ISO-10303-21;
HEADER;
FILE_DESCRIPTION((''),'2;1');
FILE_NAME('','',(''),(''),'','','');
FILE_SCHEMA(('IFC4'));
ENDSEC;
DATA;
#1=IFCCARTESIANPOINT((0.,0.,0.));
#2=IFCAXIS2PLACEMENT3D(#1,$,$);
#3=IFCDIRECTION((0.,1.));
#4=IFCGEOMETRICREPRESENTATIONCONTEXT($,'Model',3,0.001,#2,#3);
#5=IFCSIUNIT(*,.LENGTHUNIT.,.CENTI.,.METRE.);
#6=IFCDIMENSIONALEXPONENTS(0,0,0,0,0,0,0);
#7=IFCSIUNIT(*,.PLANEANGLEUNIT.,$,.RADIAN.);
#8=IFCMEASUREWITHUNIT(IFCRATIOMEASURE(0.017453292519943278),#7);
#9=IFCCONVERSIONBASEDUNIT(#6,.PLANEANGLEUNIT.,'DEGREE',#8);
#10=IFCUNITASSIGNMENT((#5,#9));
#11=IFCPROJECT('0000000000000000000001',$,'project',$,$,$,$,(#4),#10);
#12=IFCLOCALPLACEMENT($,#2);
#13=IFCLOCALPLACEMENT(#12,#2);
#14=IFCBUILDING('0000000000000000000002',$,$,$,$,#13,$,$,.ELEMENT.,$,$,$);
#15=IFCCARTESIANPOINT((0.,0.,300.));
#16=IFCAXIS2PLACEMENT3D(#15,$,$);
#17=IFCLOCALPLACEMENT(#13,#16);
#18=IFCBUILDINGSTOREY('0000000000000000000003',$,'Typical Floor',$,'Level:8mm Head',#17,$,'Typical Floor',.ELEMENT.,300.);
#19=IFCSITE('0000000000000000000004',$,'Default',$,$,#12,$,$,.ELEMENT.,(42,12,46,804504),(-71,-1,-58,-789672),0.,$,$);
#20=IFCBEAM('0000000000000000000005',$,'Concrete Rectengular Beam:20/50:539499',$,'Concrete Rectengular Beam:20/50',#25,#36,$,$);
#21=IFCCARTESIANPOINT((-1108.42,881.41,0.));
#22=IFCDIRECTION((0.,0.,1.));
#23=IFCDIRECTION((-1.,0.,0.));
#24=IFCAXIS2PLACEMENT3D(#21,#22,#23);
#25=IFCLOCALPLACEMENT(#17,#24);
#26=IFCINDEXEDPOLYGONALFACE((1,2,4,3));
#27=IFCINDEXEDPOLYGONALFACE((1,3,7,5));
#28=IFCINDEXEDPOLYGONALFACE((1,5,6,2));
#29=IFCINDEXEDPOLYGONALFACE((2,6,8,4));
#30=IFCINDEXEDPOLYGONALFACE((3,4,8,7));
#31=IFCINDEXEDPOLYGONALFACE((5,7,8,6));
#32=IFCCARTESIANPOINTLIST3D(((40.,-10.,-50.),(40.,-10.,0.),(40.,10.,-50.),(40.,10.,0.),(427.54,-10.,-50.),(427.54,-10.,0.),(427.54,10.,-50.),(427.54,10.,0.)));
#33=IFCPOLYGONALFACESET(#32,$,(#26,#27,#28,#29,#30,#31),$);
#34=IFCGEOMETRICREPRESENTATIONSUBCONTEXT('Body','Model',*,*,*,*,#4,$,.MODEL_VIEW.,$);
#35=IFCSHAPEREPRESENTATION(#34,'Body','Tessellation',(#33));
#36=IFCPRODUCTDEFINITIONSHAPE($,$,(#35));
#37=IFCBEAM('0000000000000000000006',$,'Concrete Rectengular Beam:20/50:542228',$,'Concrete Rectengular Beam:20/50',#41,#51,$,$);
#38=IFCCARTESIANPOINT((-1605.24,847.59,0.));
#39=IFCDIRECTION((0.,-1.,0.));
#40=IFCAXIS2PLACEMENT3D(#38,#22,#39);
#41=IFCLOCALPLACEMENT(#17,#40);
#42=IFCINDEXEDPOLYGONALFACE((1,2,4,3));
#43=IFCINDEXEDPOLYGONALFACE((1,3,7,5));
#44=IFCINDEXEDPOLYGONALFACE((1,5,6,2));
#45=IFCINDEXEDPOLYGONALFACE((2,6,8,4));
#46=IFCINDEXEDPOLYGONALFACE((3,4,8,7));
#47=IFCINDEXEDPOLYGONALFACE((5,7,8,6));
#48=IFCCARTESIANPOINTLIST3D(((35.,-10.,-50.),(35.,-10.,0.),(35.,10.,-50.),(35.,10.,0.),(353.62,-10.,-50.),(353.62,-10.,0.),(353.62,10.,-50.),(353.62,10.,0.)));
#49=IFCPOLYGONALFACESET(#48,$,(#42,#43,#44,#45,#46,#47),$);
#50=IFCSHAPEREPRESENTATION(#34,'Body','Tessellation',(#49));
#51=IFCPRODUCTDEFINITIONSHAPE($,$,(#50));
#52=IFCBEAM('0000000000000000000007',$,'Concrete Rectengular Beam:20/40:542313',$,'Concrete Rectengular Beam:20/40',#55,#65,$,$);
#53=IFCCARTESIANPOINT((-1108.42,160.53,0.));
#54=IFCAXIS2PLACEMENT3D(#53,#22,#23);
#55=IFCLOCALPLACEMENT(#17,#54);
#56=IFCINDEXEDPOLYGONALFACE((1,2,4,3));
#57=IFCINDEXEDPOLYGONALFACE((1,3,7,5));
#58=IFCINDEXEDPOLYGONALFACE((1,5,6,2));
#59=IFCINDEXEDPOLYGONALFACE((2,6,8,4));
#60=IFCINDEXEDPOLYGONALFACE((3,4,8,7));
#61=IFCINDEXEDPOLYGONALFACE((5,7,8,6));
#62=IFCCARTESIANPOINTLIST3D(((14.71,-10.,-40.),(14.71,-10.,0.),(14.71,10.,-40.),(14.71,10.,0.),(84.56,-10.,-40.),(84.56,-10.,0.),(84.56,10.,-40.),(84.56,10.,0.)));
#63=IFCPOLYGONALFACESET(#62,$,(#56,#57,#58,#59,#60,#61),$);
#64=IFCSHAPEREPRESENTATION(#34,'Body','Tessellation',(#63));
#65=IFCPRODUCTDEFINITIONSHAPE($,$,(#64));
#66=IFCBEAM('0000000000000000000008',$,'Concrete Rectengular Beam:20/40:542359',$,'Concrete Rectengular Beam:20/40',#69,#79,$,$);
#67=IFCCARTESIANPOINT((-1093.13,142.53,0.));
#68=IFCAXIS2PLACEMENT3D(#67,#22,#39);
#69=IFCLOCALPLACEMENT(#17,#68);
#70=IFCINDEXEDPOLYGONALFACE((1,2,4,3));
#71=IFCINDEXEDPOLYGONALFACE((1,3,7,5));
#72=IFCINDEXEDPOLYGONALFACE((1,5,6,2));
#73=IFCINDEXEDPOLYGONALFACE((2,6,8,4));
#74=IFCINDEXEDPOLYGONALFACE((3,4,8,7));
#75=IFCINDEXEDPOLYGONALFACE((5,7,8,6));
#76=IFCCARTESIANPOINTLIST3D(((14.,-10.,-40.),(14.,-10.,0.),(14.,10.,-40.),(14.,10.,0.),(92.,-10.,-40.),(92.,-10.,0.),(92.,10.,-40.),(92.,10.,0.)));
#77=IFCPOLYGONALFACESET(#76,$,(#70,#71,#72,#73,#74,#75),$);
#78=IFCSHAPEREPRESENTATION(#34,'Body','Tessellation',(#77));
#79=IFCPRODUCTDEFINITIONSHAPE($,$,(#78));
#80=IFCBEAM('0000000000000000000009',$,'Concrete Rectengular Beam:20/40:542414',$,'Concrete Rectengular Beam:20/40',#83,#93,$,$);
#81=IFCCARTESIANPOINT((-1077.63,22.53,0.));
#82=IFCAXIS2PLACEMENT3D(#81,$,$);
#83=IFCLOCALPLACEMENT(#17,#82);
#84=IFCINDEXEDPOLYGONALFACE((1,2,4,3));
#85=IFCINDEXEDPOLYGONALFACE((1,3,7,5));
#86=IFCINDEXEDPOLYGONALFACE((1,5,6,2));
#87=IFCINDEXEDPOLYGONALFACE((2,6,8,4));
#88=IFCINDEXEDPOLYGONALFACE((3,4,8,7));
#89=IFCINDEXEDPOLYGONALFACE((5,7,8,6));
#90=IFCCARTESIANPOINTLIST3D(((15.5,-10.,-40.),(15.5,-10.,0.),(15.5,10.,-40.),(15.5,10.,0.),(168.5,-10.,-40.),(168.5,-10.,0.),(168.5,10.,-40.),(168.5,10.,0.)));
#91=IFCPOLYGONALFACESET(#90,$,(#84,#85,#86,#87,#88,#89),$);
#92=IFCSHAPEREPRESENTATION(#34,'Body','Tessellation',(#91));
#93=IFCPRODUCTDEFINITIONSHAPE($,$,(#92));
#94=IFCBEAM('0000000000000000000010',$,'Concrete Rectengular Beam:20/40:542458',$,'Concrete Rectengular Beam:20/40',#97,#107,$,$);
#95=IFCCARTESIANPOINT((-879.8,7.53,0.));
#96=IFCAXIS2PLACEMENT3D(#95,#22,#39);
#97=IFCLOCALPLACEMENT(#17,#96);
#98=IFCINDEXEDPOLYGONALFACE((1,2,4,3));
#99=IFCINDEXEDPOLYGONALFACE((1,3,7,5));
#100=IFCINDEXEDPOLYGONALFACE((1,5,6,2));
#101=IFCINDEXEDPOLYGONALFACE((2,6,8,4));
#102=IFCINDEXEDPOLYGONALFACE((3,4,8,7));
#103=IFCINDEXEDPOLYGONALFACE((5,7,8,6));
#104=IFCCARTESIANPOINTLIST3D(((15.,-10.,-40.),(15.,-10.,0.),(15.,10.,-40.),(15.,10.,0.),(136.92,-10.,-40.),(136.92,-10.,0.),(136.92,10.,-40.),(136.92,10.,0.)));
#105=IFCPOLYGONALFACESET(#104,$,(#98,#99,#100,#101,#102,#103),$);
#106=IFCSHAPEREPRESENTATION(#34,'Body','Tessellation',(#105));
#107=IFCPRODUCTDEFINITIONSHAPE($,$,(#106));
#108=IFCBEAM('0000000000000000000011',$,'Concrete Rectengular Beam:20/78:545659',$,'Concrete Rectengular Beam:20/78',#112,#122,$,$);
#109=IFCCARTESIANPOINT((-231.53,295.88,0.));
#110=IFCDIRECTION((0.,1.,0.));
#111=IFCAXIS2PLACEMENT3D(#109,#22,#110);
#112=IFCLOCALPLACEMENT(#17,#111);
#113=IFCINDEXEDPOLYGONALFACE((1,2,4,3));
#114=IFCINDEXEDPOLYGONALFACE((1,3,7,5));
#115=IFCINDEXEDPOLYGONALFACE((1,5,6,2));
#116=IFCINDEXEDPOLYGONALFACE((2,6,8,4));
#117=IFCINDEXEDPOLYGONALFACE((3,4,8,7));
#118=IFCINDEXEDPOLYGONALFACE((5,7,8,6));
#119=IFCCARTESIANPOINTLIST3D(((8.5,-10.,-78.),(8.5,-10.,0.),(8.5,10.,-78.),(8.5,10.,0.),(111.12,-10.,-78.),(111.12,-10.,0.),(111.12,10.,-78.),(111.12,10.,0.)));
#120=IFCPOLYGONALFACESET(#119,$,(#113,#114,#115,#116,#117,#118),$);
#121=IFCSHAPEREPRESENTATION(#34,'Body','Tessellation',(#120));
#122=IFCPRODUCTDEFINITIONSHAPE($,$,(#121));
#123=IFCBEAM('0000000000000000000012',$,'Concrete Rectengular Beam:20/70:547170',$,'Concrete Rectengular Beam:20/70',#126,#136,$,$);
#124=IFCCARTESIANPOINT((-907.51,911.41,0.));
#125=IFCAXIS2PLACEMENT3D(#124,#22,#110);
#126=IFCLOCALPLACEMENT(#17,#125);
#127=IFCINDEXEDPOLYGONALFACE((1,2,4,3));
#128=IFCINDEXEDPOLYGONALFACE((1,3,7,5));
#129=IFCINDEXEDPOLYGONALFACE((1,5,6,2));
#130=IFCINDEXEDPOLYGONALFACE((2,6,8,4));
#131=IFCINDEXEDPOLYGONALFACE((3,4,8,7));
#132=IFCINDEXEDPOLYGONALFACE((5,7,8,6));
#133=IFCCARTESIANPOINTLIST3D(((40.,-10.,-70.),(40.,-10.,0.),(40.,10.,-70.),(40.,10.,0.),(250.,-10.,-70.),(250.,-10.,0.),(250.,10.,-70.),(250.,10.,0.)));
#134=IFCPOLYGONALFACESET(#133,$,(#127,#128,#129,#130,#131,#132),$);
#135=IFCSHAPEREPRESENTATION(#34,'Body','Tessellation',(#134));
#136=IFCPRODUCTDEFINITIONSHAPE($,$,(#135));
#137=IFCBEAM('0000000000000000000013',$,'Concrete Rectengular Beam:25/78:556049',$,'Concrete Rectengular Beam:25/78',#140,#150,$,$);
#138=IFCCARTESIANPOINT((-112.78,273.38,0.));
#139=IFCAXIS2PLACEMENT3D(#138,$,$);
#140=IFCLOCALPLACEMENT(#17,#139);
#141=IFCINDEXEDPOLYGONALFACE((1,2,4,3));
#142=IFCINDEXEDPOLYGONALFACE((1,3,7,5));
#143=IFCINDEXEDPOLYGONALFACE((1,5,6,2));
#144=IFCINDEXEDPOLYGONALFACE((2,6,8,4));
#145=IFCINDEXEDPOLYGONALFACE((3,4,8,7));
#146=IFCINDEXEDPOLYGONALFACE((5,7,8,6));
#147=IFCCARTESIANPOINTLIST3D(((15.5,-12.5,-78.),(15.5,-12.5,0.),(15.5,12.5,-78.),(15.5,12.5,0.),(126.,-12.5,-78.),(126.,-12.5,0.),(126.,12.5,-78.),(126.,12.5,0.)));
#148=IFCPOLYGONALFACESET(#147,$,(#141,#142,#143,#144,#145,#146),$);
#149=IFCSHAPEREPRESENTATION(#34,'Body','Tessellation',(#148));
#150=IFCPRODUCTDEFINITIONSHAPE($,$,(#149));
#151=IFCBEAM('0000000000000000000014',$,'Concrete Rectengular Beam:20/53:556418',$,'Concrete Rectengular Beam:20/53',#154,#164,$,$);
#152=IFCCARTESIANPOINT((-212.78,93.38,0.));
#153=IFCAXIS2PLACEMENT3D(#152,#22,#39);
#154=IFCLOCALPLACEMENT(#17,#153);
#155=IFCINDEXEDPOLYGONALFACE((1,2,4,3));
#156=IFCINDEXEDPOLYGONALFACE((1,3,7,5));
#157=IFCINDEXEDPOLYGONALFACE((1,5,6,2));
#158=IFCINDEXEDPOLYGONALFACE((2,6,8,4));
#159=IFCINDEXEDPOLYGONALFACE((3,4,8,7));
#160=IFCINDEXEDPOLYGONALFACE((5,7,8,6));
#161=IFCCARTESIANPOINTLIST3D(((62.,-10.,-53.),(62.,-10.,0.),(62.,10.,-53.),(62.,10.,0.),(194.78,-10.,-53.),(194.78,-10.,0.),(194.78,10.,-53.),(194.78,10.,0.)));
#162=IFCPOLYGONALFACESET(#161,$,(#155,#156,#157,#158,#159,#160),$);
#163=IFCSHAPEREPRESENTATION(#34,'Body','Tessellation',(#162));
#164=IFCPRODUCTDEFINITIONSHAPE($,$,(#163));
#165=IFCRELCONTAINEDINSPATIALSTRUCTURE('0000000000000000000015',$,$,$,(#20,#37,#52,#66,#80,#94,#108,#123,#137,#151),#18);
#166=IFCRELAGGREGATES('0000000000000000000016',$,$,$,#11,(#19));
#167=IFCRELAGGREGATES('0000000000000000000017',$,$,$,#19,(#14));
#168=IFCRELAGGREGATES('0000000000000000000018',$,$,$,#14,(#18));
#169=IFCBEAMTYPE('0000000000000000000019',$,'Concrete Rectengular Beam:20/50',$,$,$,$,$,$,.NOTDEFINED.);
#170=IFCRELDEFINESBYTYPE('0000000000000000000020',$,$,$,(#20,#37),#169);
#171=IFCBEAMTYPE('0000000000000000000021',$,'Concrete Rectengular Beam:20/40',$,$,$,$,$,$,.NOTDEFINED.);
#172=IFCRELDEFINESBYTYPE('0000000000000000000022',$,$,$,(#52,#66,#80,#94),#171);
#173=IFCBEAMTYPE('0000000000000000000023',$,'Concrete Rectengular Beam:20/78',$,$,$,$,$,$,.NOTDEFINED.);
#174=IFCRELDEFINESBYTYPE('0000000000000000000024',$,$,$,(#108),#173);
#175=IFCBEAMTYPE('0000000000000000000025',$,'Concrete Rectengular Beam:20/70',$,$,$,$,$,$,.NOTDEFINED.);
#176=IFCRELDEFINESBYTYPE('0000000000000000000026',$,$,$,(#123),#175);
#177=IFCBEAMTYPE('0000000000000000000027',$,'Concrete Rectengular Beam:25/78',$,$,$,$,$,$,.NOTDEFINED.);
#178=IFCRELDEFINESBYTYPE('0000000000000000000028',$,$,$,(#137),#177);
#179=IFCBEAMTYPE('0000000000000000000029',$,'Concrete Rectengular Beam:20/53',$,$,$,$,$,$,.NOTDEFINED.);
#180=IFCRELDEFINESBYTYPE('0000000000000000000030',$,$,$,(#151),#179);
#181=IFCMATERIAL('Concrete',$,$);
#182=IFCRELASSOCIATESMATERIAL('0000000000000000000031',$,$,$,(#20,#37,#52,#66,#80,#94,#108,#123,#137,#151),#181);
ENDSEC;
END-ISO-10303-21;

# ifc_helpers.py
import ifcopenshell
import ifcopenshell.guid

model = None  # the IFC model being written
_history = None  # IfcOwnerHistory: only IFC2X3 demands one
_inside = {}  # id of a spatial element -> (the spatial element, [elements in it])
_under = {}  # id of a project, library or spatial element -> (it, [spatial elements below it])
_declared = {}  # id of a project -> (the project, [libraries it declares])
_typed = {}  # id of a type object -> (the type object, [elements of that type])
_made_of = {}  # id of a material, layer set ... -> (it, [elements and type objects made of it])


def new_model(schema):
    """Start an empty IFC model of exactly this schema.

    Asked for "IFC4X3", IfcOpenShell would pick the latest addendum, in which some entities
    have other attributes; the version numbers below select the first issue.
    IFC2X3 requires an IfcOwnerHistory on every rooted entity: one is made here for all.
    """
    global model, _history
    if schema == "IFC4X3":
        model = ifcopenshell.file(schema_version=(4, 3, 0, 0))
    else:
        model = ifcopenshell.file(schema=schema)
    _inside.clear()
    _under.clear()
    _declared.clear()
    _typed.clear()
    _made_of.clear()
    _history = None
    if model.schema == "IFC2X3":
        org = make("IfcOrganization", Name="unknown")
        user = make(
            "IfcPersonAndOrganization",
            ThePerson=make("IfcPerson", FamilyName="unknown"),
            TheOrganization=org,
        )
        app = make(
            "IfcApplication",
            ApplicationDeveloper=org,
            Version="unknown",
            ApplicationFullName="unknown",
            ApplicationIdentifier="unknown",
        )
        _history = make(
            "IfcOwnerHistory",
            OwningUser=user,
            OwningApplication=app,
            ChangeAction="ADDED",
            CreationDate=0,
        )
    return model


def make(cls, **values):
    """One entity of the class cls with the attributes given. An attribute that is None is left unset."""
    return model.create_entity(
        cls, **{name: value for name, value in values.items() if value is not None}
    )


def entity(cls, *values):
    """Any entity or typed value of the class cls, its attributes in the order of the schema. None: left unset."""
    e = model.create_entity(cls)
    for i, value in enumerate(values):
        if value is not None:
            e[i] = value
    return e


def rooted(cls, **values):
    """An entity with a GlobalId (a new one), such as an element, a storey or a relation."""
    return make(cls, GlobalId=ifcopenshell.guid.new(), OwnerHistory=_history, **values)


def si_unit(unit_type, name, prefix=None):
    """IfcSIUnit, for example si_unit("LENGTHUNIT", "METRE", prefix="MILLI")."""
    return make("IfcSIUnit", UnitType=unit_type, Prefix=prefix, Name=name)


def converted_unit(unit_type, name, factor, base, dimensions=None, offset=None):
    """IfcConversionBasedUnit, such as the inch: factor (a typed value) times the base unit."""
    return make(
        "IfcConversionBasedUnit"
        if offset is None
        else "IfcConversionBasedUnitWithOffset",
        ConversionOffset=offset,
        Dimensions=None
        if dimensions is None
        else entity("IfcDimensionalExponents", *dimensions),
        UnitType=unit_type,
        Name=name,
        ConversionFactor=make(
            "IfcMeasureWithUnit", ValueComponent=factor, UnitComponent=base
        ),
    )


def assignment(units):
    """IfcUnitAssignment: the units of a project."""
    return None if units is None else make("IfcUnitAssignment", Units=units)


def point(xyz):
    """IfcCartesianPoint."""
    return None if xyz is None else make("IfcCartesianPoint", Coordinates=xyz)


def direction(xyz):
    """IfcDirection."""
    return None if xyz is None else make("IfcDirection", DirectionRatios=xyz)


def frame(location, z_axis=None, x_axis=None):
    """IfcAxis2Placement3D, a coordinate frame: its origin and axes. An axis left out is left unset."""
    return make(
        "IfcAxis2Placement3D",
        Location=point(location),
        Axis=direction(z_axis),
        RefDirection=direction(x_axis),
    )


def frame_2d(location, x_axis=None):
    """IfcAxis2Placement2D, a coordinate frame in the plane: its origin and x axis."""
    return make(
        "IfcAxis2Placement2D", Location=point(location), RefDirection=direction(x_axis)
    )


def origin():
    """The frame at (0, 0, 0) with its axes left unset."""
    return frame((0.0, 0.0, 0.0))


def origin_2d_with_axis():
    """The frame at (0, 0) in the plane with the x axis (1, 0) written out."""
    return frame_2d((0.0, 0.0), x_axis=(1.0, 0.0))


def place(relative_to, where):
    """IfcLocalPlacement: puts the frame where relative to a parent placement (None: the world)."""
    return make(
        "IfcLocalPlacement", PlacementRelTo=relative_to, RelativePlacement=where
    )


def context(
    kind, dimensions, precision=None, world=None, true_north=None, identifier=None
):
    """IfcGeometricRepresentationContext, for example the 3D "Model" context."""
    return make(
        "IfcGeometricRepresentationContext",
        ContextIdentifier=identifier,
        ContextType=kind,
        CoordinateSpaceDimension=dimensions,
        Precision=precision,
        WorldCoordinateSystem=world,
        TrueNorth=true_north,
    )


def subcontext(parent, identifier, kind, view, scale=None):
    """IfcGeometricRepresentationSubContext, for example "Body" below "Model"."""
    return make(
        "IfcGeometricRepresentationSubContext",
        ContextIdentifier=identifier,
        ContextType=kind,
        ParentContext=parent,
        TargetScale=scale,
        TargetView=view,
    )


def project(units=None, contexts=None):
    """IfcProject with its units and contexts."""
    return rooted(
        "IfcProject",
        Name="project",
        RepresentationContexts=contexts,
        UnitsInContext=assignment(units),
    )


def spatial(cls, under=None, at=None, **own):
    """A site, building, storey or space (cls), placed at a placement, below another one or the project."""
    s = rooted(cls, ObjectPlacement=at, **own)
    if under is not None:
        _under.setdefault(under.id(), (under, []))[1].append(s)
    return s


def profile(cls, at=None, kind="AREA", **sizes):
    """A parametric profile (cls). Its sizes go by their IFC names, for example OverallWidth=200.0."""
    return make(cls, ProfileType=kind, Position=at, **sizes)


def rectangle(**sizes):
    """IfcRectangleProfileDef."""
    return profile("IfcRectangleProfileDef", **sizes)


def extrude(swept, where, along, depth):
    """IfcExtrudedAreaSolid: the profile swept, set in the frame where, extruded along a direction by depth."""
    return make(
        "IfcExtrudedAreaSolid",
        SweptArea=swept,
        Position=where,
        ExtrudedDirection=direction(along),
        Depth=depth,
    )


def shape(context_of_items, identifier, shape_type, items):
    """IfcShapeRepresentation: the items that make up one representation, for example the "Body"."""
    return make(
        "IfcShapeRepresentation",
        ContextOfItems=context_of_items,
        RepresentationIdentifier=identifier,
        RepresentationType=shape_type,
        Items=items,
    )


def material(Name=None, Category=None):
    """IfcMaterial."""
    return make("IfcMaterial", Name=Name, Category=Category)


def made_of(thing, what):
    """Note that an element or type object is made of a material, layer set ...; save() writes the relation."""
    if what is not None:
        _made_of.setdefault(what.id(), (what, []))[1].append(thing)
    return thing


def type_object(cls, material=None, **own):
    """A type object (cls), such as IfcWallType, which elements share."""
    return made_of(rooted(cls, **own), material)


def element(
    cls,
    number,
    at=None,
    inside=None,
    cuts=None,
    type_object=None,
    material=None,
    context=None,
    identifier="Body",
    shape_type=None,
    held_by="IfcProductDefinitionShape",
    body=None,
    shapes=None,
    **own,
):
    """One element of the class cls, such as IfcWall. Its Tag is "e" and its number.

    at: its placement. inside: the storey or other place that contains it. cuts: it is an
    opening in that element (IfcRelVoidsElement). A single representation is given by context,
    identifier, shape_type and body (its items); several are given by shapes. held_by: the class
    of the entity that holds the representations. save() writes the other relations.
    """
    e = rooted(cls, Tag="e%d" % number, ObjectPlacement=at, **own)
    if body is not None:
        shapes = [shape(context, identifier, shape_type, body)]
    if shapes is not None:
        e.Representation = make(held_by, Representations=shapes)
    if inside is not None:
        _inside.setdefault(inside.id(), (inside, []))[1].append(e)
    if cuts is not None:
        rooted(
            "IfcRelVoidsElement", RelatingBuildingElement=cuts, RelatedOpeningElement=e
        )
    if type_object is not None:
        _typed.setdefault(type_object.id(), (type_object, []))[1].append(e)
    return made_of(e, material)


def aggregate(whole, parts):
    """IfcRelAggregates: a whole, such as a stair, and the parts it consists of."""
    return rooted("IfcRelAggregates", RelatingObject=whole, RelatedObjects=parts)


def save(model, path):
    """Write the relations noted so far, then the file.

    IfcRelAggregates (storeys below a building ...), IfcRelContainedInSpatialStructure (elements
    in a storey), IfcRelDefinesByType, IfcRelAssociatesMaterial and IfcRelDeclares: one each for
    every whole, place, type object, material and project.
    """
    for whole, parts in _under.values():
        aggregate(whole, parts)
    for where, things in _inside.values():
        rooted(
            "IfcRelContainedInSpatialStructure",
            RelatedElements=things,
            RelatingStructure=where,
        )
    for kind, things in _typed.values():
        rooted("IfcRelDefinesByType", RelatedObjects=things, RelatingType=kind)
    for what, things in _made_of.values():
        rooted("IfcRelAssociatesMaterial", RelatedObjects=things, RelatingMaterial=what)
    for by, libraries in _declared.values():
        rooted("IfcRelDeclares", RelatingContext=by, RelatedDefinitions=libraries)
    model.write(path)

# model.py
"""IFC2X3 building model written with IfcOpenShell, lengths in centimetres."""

from ifc_helpers import new_model, entity, si_unit, converted_unit, direction, frame, frame_2d, origin, origin_2d_with_axis, place, context, subcontext, project, spatial, rectangle, extrude, material, type_object, element, save


model = new_model("IFC2X3")

# Units and contexts
model_context = context("Model", 3, precision=0.001, world=origin(), true_north=direction((0.0, 1.0)))
body_context = subcontext(model_context, "Body", "Model", "MODEL_VIEW")
ifc_project = project(units=[si_unit("LENGTHUNIT", "METRE", prefix="CENTI"), converted_unit("PLANEANGLEUNIT", "DEGREE", entity("IfcRatioMeasure", 0.017453292519943278), si_unit("PLANEANGLEUNIT", "RADIAN"), dimensions=[0, 0, 0, 0, 0, 0, 0])], contexts=[model_context])

# Site, building, storey
site_placement = place(None, origin())
site = spatial("IfcSite", under=ifc_project, at=site_placement, Name="Default", CompositionType="ELEMENT", RefLatitude=(42, 12, 46, 804504), RefLongitude=(-71, -1, -58, -789672), RefElevation=0.0)
building_placement = place(site_placement, origin())
building = spatial("IfcBuilding", under=site, at=building_placement, CompositionType="ELEMENT")
storey_placement = place(building_placement, frame((0.0, 0.0, 300.0)))
storey = spatial("IfcBuildingStorey", under=building, at=storey_placement, Name="Typical Floor", ObjectType="Level:8mm Head", LongName="Typical Floor", CompositionType="ELEMENT", Elevation=300.0)

# Beams
ifc_material = material(Name="Concrete")
beam_type_1 = type_object("IfcBeamType", Name="Concrete Rectengular Beam:20/50", PredefinedType="NOTDEFINED")
beam_1_placement = place(storey_placement, frame((-1108.42, 881.41, 0.0), z_axis=(0.0, 0.0, 1.0), x_axis=(-1.0, 0.0, 0.0)))
element("IfcBeam", 1, at=beam_1_placement, inside=storey, type_object=beam_type_1, material=ifc_material, Name="Concrete Rectengular Beam:20/50:539499", ObjectType="Concrete Rectengular Beam:20/50", context=body_context, shape_type="SweptSolid", body=[
    extrude(rectangle(XDim=50.0, YDim=20.0, at=frame_2d((0.0, 0.0), x_axis=(1.0, 0.0))), frame((40.0, 0.0, -25.0), z_axis=(1.0, 0.0, 0.0), x_axis=(0.0, 0.0, -1.0)), (0.0, 0.0, 1.0), 387.54),
])
beam_2_placement = place(storey_placement, frame((-1605.24, 847.59, 0.0), z_axis=(0.0, 0.0, 1.0), x_axis=(0.0, -1.0, 0.0)))
element("IfcBeam", 2, at=beam_2_placement, inside=storey, type_object=beam_type_1, material=ifc_material, Name="Concrete Rectengular Beam:20/50:542228", ObjectType="Concrete Rectengular Beam:20/50", context=body_context, shape_type="SweptSolid", body=[
    extrude(rectangle(XDim=50.0, YDim=20.0, at=frame_2d((0.0, 0.0), x_axis=(1.0, 0.0))), frame((35.0, 0.0, -25.0), z_axis=(1.0, 0.0, 0.0), x_axis=(0.0, 0.0, -1.0)), (0.0, 0.0, 1.0), 318.62),
])
beam_type_2 = type_object("IfcBeamType", Name="Concrete Rectengular Beam:20/40", PredefinedType="NOTDEFINED")
beam_3_placement = place(storey_placement, frame((-1108.42, 160.53, 0.0), z_axis=(0.0, 0.0, 1.0), x_axis=(-1.0, 0.0, 0.0)))
element("IfcBeam", 3, at=beam_3_placement, inside=storey, type_object=beam_type_2, material=ifc_material, Name="Concrete Rectengular Beam:20/40:542313", ObjectType="Concrete Rectengular Beam:20/40", context=body_context, shape_type="SweptSolid", body=[
    extrude(rectangle(XDim=40.0, YDim=20.0, at=frame_2d((0.0, 0.0), x_axis=(1.0, 0.0))), frame((14.71, 0.0, -20.0), z_axis=(1.0, 0.0, 0.0), x_axis=(0.0, 0.0, -1.0)), (0.0, 0.0, 1.0), 69.85),
])
beam_4_placement = place(storey_placement, frame((-1093.13, 142.53, 0.0), z_axis=(0.0, 0.0, 1.0), x_axis=(0.0, -1.0, 0.0)))
element("IfcBeam", 4, at=beam_4_placement, inside=storey, type_object=beam_type_2, material=ifc_material, Name="Concrete Rectengular Beam:20/40:542359", ObjectType="Concrete Rectengular Beam:20/40", context=body_context, shape_type="SweptSolid", body=[
    extrude(rectangle(XDim=40.0, YDim=20.0, at=origin_2d_with_axis()), frame((14.0, 0.0, -20.0), z_axis=(1.0, 0.0, 0.0), x_axis=(0.0, 0.0, -1.0)), (0.0, 0.0, 1.0), 78.0),
])
beam_5_placement = place(storey_placement, frame((-1077.63, 22.53, 0.0)))
element("IfcBeam", 5, at=beam_5_placement, inside=storey, type_object=beam_type_2, material=ifc_material, Name="Concrete Rectengular Beam:20/40:542414", ObjectType="Concrete Rectengular Beam:20/40", context=body_context, shape_type="SweptSolid", body=[
    extrude(rectangle(XDim=40.0, YDim=20.0, at=frame_2d((0.0, 0.0), x_axis=(1.0, 0.0))), frame((15.5, 0.0, -20.0), z_axis=(1.0, 0.0, 0.0), x_axis=(0.0, 0.0, -1.0)), (0.0, 0.0, 1.0), 153.0),
])
beam_6_placement = place(storey_placement, frame((-879.8, 7.53, 0.0), z_axis=(0.0, 0.0, 1.0), x_axis=(0.0, -1.0, 0.0)))
element("IfcBeam", 6, at=beam_6_placement, inside=storey, type_object=beam_type_2, material=ifc_material, Name="Concrete Rectengular Beam:20/40:542458", ObjectType="Concrete Rectengular Beam:20/40", context=body_context, shape_type="SweptSolid", body=[
    extrude(rectangle(XDim=40.0, YDim=20.0, at=frame_2d((0.0, 0.0), x_axis=(1.0, 0.0))), frame((15.0, 0.0, -20.0), z_axis=(1.0, 0.0, 0.0), x_axis=(0.0, 0.0, -1.0)), (0.0, 0.0, 1.0), 121.92),
])
beam_type_3 = type_object("IfcBeamType", Name="Concrete Rectengular Beam:20/78", PredefinedType="NOTDEFINED")
beam_7_placement = place(storey_placement, frame((-231.53, 295.88, 0.0), z_axis=(0.0, 0.0, 1.0), x_axis=(0.0, 1.0, 0.0)))
element("IfcBeam", 7, at=beam_7_placement, inside=storey, type_object=beam_type_3, material=ifc_material, Name="Concrete Rectengular Beam:20/78:545659", ObjectType="Concrete Rectengular Beam:20/78", context=body_context, shape_type="SweptSolid", body=[
    extrude(rectangle(XDim=78.0, YDim=20.0, at=frame_2d((0.0, 0.0), x_axis=(1.0, 0.0))), frame((8.5, 0.0, -39.0), z_axis=(1.0, 0.0, 0.0), x_axis=(0.0, 0.0, -1.0)), (0.0, 0.0, 1.0), 102.62),
])
beam_type_4 = type_object("IfcBeamType", Name="Concrete Rectengular Beam:20/70", PredefinedType="NOTDEFINED")
beam_8_placement = place(storey_placement, frame((-907.51, 911.41, 0.0), z_axis=(0.0, 0.0, 1.0), x_axis=(0.0, 1.0, 0.0)))
element("IfcBeam", 8, at=beam_8_placement, inside=storey, type_object=beam_type_4, material=ifc_material, Name="Concrete Rectengular Beam:20/70:547170", ObjectType="Concrete Rectengular Beam:20/70", context=body_context, shape_type="SweptSolid", body=[
    extrude(rectangle(XDim=70.0, YDim=20.0, at=frame_2d((0.0, 0.0), x_axis=(1.0, 0.0))), frame((40.0, 0.0, -35.0), z_axis=(1.0, 0.0, 0.0), x_axis=(0.0, 0.0, -1.0)), (0.0, 0.0, 1.0), 210.0),
])
beam_type_5 = type_object("IfcBeamType", Name="Concrete Rectengular Beam:25/78", PredefinedType="NOTDEFINED")
beam_9_placement = place(storey_placement, frame((-112.78, 273.38, 0.0)))
element("IfcBeam", 9, at=beam_9_placement, inside=storey, type_object=beam_type_5, material=ifc_material, Name="Concrete Rectengular Beam:25/78:556049", ObjectType="Concrete Rectengular Beam:25/78", context=body_context, shape_type="SweptSolid", body=[
    extrude(rectangle(XDim=78.0, YDim=25.0, at=frame_2d((0.0, 0.0), x_axis=(1.0, 0.0))), frame((15.5, 0.0, -39.0), z_axis=(1.0, 0.0, 0.0), x_axis=(0.0, 0.0, -1.0)), (0.0, 0.0, 1.0), 110.5),
])
beam_type_6 = type_object("IfcBeamType", Name="Concrete Rectengular Beam:20/53", PredefinedType="NOTDEFINED")
beam_10_placement = place(storey_placement, frame((-212.78, 93.38, 0.0), z_axis=(0.0, 0.0, 1.0), x_axis=(0.0, -1.0, 0.0)))
element("IfcBeam", 10, at=beam_10_placement, inside=storey, type_object=beam_type_6, material=ifc_material, Name="Concrete Rectengular Beam:20/53:556418", ObjectType="Concrete Rectengular Beam:20/53", context=body_context, shape_type="SweptSolid", body=[
    extrude(rectangle(XDim=53.0, YDim=20.0, at=origin_2d_with_axis()), frame((62.0, 0.0, -26.5), z_axis=(1.0, 0.0, 0.0), x_axis=(0.0, 0.0, -1.0)), (0.0, 0.0, 1.0), 132.78),
])

save(model, "model.ifc")
